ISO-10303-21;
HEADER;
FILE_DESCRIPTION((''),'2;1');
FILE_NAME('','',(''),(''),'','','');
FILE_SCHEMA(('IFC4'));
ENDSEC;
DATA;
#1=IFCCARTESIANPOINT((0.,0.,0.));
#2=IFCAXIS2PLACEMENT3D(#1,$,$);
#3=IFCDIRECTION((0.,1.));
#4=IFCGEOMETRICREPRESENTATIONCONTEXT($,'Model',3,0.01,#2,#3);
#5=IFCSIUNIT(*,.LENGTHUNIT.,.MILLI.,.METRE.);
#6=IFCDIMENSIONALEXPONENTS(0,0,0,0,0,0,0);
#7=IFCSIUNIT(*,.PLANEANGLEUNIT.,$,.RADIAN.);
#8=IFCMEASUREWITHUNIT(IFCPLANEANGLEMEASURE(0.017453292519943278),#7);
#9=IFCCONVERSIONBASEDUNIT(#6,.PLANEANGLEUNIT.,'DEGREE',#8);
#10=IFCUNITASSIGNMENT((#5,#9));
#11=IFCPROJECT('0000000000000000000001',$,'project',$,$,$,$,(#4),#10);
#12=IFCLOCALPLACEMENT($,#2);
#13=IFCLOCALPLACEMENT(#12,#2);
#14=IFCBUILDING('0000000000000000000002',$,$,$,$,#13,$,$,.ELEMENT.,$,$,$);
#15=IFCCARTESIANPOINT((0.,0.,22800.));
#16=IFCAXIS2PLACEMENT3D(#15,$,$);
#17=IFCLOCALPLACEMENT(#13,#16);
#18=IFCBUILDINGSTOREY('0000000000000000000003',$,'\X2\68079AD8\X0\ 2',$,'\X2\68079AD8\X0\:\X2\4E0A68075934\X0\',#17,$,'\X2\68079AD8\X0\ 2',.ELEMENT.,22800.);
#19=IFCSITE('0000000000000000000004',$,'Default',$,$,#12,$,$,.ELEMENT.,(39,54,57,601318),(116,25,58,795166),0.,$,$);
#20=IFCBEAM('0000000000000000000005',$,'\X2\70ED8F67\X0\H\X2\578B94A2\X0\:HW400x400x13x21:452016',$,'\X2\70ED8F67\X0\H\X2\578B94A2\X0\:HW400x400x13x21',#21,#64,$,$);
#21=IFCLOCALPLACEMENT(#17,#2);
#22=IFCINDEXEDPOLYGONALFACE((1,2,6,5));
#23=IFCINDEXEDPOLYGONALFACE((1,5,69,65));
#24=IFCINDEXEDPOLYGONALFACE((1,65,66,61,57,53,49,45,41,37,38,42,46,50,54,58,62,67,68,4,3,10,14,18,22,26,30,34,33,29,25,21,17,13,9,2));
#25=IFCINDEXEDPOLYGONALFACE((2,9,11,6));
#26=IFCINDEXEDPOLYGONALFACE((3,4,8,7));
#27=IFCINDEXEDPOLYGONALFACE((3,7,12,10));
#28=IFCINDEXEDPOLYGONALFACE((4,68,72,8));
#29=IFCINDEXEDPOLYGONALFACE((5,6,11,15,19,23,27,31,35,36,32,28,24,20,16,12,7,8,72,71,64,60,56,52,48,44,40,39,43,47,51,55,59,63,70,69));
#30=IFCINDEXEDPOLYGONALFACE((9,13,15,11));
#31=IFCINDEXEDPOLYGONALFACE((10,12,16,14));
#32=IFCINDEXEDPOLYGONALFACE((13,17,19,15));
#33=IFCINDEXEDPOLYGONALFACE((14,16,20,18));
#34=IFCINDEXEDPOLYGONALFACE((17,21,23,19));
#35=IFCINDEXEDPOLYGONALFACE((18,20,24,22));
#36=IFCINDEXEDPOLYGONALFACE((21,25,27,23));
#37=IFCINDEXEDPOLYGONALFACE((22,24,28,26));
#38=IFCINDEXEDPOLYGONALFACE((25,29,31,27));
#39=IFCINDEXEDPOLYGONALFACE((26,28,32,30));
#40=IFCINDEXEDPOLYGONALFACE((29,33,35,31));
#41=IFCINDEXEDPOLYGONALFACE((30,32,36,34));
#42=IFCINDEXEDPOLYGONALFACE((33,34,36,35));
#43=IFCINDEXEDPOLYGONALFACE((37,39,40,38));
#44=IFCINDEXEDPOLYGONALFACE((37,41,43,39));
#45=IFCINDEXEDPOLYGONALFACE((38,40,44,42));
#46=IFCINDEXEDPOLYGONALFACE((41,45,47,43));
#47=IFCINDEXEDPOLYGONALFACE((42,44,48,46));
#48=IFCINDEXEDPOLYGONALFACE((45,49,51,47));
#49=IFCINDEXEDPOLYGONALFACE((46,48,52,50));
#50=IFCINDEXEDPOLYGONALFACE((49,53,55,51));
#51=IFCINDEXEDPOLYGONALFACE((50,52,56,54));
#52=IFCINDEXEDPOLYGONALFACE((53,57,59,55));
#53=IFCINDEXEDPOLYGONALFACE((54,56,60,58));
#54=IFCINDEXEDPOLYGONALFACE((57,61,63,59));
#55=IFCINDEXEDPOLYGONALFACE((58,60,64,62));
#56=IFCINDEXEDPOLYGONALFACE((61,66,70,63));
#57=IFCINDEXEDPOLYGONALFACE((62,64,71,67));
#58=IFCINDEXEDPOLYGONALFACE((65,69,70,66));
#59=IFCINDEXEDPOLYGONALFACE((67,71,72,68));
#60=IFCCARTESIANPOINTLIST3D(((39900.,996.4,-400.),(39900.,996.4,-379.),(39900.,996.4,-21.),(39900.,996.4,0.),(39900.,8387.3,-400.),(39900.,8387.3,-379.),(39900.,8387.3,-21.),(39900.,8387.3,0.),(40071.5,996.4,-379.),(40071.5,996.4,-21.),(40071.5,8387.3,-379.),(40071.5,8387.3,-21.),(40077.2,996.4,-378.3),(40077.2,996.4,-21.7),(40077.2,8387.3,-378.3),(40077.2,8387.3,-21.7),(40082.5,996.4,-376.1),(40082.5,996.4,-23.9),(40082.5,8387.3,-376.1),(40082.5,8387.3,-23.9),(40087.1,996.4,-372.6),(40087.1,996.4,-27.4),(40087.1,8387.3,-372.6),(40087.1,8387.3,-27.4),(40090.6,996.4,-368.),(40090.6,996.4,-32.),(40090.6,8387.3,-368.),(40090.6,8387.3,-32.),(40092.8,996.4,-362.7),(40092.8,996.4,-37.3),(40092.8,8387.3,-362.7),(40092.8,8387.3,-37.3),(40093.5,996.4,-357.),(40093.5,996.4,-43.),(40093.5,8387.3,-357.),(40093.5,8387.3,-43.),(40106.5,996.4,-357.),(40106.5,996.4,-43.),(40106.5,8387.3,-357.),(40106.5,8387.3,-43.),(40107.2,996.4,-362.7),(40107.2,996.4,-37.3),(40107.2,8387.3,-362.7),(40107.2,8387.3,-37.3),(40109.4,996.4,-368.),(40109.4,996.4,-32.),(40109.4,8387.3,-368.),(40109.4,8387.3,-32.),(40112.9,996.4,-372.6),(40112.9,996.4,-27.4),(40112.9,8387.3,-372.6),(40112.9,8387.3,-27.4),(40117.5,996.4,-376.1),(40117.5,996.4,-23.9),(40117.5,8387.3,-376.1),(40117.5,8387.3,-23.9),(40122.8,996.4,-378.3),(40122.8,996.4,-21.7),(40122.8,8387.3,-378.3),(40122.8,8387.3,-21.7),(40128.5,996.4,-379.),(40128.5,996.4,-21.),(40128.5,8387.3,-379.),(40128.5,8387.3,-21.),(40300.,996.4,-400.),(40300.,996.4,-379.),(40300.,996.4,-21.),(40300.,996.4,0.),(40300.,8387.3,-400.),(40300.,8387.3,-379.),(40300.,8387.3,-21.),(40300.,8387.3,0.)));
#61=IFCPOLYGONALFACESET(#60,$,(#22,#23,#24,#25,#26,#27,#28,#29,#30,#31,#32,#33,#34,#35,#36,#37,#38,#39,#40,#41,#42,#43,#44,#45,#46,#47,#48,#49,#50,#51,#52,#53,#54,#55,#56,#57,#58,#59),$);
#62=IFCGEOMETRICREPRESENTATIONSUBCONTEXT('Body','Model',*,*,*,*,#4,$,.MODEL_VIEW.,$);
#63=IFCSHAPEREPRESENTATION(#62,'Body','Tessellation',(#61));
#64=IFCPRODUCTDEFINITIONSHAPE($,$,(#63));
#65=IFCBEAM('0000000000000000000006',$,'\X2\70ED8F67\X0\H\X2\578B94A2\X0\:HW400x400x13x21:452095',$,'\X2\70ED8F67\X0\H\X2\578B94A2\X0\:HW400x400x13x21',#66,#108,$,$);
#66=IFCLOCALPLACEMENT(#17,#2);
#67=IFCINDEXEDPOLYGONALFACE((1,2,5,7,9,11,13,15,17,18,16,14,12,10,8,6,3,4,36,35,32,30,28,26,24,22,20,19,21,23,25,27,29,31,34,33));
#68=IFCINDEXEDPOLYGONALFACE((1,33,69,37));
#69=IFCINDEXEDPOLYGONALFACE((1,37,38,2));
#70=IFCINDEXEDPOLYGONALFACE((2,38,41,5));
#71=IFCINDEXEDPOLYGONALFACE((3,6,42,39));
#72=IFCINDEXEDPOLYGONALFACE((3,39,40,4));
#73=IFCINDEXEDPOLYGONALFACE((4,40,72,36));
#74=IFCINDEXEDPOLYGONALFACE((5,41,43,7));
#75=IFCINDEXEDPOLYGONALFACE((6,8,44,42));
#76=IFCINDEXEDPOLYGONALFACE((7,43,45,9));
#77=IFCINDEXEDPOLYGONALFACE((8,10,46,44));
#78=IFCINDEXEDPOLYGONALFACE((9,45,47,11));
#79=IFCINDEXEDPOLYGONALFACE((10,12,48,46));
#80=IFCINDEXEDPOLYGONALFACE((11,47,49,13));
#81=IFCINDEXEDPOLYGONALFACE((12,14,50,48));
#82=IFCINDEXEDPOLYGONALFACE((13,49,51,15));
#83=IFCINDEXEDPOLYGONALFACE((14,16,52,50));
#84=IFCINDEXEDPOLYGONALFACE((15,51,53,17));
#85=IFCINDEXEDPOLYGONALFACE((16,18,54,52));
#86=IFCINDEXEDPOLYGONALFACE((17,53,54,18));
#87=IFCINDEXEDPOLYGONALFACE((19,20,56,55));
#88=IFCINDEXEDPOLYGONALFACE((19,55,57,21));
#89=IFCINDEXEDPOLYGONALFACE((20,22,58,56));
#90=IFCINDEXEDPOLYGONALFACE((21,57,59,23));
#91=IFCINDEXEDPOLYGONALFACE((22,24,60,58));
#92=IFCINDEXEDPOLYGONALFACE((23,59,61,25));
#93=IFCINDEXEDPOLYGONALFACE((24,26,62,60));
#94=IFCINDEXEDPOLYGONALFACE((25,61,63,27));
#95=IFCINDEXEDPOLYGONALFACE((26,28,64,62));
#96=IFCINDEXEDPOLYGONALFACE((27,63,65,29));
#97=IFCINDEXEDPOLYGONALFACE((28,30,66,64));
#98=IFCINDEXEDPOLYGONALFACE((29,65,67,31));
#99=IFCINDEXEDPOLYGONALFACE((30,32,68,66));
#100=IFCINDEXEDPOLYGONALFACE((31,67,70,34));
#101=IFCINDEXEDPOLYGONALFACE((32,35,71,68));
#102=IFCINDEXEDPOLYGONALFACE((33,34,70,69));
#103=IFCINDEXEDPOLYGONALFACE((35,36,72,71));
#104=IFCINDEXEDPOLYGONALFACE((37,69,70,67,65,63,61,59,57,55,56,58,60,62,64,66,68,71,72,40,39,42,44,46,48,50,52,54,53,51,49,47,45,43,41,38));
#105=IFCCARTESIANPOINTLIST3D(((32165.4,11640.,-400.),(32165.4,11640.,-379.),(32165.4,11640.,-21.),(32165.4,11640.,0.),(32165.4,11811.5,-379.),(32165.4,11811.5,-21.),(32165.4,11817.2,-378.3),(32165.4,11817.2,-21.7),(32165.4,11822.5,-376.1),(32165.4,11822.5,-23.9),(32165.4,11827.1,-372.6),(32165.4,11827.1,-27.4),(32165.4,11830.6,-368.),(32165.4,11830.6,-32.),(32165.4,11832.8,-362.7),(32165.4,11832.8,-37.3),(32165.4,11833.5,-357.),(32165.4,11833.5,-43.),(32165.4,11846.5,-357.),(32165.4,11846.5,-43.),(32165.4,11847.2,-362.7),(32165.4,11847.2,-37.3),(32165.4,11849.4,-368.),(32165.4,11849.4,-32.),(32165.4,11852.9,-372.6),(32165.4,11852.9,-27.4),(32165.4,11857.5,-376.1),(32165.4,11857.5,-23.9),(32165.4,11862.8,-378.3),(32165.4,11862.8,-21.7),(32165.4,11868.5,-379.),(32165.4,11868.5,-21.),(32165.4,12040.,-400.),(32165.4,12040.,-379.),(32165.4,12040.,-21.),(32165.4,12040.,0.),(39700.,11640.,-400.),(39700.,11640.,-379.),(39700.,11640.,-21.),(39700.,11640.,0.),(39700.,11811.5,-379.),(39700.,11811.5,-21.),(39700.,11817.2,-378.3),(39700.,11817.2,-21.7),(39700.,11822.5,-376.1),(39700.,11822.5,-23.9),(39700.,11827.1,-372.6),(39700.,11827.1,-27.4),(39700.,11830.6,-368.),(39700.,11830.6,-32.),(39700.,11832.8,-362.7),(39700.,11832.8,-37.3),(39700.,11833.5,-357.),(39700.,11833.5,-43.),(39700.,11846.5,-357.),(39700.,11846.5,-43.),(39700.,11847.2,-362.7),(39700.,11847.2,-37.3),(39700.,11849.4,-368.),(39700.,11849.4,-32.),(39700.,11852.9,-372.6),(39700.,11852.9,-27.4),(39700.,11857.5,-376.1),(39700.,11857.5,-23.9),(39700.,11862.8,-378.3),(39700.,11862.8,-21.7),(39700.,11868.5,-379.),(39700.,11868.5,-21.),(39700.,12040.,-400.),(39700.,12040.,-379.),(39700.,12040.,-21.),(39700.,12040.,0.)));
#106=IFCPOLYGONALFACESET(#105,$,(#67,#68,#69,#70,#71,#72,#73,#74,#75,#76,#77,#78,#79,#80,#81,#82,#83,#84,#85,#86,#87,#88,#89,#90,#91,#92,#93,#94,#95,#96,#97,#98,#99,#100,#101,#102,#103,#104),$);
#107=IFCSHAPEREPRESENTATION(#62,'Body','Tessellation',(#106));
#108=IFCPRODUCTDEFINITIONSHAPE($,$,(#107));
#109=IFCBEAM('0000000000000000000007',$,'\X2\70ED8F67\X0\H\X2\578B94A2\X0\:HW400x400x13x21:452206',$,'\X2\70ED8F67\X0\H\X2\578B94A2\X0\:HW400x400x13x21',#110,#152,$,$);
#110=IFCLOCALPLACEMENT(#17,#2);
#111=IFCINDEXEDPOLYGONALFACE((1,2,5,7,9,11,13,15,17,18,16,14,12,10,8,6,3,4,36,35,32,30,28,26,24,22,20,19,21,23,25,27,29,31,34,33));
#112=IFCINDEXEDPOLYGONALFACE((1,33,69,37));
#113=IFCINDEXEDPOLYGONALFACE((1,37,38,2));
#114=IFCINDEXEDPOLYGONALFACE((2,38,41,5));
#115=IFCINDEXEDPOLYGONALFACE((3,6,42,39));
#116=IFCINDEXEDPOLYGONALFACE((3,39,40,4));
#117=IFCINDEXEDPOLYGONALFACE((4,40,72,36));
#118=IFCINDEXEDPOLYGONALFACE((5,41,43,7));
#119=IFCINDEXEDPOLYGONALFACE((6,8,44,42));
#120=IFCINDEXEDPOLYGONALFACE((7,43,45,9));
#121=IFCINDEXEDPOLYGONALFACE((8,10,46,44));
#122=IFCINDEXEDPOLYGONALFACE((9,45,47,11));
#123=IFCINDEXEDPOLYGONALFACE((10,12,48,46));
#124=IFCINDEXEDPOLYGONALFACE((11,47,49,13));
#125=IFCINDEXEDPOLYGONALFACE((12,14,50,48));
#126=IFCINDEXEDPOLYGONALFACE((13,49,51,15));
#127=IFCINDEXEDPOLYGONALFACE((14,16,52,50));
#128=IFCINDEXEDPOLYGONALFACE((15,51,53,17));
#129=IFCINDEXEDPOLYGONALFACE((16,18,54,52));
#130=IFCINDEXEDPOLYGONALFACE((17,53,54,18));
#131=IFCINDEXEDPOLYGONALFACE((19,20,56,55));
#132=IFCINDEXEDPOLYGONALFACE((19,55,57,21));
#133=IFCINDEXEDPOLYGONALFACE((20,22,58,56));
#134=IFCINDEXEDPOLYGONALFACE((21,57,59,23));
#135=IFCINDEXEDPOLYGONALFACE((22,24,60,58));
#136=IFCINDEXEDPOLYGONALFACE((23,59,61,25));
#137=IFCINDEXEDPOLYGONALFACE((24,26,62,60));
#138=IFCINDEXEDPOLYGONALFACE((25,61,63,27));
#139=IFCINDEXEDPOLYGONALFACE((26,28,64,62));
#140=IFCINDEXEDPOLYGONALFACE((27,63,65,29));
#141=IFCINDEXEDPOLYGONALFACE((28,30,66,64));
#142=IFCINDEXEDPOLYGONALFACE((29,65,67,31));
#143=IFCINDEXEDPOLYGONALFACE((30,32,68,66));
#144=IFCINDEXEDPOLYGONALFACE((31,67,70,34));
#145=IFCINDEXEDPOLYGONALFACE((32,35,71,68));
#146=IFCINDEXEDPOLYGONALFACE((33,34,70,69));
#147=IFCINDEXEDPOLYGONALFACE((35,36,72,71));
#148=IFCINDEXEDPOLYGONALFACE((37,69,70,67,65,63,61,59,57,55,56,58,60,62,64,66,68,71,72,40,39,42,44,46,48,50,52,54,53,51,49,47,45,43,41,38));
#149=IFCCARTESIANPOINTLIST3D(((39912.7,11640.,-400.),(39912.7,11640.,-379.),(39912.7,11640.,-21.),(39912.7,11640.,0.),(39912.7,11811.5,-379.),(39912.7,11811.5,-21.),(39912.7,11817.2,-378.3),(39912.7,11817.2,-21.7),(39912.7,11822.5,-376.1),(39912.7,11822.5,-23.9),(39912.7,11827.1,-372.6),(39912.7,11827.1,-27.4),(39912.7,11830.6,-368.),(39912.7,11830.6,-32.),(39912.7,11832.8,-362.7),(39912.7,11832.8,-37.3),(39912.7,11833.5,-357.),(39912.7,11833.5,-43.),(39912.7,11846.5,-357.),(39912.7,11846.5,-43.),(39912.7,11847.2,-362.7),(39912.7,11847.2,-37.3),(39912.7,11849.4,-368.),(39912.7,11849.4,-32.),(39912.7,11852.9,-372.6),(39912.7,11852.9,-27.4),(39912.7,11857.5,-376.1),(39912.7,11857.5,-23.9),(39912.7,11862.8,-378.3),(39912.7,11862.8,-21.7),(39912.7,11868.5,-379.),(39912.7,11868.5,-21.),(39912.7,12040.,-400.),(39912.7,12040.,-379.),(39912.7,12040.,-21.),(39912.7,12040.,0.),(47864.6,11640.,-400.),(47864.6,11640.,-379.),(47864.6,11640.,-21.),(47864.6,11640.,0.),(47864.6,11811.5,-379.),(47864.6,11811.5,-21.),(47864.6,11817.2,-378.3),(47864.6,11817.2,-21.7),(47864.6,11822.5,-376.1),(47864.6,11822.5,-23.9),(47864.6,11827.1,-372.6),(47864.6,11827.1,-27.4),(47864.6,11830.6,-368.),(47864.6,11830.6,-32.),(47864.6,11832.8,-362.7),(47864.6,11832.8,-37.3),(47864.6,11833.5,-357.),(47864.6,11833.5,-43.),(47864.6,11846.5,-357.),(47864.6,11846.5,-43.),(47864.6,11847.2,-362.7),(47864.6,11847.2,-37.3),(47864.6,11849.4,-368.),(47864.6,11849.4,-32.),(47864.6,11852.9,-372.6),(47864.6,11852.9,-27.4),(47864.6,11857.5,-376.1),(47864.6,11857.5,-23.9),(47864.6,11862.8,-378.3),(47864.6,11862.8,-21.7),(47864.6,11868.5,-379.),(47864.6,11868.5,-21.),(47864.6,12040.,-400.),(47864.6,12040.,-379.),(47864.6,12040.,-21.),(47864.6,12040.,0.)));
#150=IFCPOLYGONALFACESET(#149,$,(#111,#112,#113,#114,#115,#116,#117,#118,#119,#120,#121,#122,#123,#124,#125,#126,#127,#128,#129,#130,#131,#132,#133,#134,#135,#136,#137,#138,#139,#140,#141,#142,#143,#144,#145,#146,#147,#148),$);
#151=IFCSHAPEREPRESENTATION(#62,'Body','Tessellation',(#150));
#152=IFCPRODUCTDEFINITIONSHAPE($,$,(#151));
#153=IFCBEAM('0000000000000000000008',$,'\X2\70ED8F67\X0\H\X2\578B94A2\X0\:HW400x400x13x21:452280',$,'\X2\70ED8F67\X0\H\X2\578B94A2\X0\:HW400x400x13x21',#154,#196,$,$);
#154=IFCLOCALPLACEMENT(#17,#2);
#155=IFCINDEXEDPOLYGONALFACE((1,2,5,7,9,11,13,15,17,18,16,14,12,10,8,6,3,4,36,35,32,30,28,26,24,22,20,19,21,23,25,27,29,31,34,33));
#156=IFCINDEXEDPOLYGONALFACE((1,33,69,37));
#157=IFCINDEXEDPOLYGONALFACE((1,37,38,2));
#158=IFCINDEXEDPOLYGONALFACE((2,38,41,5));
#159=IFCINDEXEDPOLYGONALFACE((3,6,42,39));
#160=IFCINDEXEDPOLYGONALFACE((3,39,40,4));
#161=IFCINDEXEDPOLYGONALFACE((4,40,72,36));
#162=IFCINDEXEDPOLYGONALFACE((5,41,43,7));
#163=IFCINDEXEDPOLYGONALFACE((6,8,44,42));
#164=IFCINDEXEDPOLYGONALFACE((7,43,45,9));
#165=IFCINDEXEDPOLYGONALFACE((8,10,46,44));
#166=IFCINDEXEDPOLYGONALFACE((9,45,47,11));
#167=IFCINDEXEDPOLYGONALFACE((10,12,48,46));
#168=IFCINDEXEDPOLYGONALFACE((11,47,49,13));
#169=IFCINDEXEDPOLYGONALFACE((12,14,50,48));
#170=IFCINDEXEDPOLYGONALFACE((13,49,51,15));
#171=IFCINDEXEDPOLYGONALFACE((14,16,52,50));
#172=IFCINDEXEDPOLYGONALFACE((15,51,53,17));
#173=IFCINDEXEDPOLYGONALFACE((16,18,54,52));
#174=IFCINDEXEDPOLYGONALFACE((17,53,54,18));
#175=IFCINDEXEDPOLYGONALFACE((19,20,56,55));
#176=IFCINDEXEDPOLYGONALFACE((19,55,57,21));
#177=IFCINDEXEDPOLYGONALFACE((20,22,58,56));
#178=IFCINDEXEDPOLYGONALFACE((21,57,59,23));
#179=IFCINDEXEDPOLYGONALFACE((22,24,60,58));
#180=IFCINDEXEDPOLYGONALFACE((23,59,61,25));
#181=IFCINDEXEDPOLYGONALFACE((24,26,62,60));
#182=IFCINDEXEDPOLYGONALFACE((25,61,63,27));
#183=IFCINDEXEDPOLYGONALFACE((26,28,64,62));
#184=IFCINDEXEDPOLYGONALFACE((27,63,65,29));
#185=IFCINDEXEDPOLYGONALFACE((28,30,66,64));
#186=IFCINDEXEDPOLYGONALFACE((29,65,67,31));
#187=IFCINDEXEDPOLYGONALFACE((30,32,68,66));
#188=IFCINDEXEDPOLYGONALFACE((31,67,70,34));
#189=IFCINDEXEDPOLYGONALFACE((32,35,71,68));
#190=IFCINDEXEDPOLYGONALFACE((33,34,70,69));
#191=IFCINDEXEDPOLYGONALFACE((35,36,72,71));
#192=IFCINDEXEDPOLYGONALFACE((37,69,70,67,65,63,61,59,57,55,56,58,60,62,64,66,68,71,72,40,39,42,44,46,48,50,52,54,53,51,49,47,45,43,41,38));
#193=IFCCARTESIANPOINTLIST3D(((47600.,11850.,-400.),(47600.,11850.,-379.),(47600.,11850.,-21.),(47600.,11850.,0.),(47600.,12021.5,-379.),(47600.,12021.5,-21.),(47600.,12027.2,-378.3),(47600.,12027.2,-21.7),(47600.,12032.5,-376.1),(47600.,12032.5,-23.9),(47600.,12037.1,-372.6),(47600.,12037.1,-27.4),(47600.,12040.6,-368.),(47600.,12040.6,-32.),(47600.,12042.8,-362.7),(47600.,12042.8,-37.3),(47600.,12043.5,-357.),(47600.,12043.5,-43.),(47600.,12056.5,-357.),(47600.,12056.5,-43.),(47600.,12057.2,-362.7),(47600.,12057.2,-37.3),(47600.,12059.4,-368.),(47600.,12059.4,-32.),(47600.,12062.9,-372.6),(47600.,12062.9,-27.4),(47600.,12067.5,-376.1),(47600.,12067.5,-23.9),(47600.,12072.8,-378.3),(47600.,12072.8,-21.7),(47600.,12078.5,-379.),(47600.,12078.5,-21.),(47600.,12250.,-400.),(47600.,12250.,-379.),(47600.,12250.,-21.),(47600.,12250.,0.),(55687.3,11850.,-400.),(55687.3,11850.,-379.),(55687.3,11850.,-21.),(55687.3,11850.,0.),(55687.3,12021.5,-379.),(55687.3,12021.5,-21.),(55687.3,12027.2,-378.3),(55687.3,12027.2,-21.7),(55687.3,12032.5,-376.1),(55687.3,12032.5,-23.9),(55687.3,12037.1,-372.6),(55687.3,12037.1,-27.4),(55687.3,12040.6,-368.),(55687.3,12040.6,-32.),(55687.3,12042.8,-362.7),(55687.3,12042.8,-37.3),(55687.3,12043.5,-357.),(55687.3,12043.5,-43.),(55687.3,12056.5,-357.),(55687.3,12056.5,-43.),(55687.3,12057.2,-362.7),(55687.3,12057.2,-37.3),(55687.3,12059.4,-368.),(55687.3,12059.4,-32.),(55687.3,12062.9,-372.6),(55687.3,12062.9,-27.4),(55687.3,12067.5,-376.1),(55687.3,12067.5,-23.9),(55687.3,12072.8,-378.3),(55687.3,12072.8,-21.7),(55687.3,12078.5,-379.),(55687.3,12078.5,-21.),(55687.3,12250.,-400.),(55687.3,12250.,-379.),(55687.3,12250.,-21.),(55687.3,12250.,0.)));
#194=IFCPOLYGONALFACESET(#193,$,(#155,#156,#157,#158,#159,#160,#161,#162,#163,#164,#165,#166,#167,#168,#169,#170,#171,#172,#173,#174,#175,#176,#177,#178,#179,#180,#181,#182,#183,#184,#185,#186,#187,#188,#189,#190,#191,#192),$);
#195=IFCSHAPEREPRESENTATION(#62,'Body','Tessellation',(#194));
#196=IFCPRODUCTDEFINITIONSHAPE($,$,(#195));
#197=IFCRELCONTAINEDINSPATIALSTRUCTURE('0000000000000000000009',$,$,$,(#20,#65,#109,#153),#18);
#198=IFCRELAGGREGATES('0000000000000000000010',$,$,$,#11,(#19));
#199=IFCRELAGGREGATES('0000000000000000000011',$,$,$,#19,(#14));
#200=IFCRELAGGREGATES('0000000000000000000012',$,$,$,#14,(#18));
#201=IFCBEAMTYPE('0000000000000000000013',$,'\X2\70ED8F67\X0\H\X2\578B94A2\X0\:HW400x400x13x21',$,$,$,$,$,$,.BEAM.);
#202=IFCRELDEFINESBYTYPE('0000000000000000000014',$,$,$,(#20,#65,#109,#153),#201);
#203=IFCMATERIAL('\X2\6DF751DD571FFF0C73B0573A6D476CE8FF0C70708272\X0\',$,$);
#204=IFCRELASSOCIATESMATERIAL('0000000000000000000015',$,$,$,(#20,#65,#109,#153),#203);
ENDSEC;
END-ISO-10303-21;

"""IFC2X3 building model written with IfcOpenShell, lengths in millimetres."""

from ifc_helpers import new_model, entity, si_unit, converted_unit, direction, frame, frame_2d, origin, place, context, subcontext, project, spatial, i_section, extrude, material, type_object, element, save


model = new_model("IFC2X3")

# Units and contexts
model_context = context("Model", 3, precision=0.01, world=origin(), true_north=direction((0.0, 1.0)))
body_context = subcontext(model_context, "Body", "Model", "MODEL_VIEW")
ifc_project = project(units=[si_unit("LENGTHUNIT", "METRE", prefix="MILLI"), converted_unit("PLANEANGLEUNIT", "DEGREE", entity("IfcPlaneAngleMeasure", 0.017453292519943278), si_unit("PLANEANGLEUNIT", "RADIAN"), dimensions=[0, 0, 0, 0, 0, 0, 0])], contexts=[model_context])

# Site, building, storey
site_placement = place(None, origin())
site = spatial("IfcSite", under=ifc_project, at=site_placement, Name="Default", CompositionType="ELEMENT", RefLatitude=(39, 54, 57, 601318), RefLongitude=(116, 25, 58, 795166), RefElevation=0.0)
building_placement = place(site_placement, origin())
building = spatial("IfcBuilding", under=site, at=building_placement, CompositionType="ELEMENT")
storey_placement = place(building_placement, frame((0.0, 0.0, 22800.0)))
storey = spatial("IfcBuildingStorey", under=building, at=storey_placement, Name="标高 2", ObjectType="标高:上标头", LongName="标高 2", CompositionType="ELEMENT", Elevation=22800.0)

# Beams
ifc_material = material(Name="混凝土，现场浇注，灰色")
beam_type = type_object("IfcBeamType", Name="热轧H型钢:HW400x400x13x21", PredefinedType="BEAM")
beam_1_placement = place(storey_placement, frame((40100.0, 8600.0, 0.0), z_axis=(0.0, 0.0, 1.0), x_axis=(0.0, -1.0, 0.0)))
element("IfcBeam", 1, at=beam_1_placement, inside=storey, type_object=beam_type, material=ifc_material, Name="热轧H型钢:HW400x400x13x21:452016", ObjectType="热轧H型钢:HW400x400x13x21", context=body_context, shape_type="SweptSolid", body=[
    extrude(i_section(OverallWidth=400.0, OverallDepth=400.0, WebThickness=13.0, FlangeThickness=21.0, FilletRadius=22.0, at=frame_2d((0.0, 0.0), x_axis=(0.0, 1.0))), frame((212.7, 0.0, -200.0), z_axis=(1.0, 0.0, 0.0), x_axis=(0.0, 0.0, -1.0)), (0.0, 0.0, 1.0), 7390.9),
])
beam_2_placement = place(storey_placement, frame((39700.0, 11840.0, 0.0), z_axis=(0.0, 0.0, 1.0), x_axis=(-1.0, 0.0, 0.0)))
element("IfcBeam", 2, at=beam_2_placement, inside=storey, type_object=beam_type, material=ifc_material, Name="热轧H型钢:HW400x400x13x21:452095", ObjectType="热轧H型钢:HW400x400x13x21", context=body_context, shape_type="SweptSolid", body=[
    extrude(i_section(OverallWidth=400.0, OverallDepth=400.0, WebThickness=13.0, FlangeThickness=21.0, FilletRadius=22.0, at=frame_2d((0.0, 0.0), x_axis=(0.0, 1.0))), frame((0.0, 0.0, -200.0), z_axis=(1.0, 0.0, 0.0), x_axis=(0.0, 0.0, -1.0)), (0.0, 0.0, 1.0), 7534.6),
])
beam_3_placement = place(storey_placement, frame((48125.0, 11840.0, 0.0), z_axis=(0.0, 0.0, 1.0), x_axis=(-1.0, 0.0, 0.0)))
element("IfcBeam", 3, at=beam_3_placement, inside=storey, type_object=beam_type, material=ifc_material, Name="热轧H型钢:HW400x400x13x21:452206", ObjectType="热轧H型钢:HW400x400x13x21", context=body_context, shape_type="SweptSolid", body=[
    extrude(i_section(OverallWidth=400.0, OverallDepth=400.0, WebThickness=13.0, FlangeThickness=21.0, FilletRadius=22.0, at=frame_2d((0.0, 0.0), x_axis=(0.0, 1.0))), frame((260.4, 0.0, -200.0), z_axis=(1.0, 0.0, 0.0), x_axis=(0.0, 0.0, -1.0)), (0.0, 0.0, 1.0), 7951.9),
])
beam_4_placement = place(storey_placement, frame((55900.0, 12050.0, 0.0), z_axis=(0.0, 0.0, 1.0), x_axis=(-1.0, 0.0, 0.0)))
element("IfcBeam", 4, at=beam_4_placement, inside=storey, type_object=beam_type, material=ifc_material, Name="热轧H型钢:HW400x400x13x21:452280", ObjectType="热轧H型钢:HW400x400x13x21", context=body_context, shape_type="SweptSolid", body=[
    extrude(i_section(OverallWidth=400.0, OverallDepth=400.0, WebThickness=13.0, FlangeThickness=21.0, FilletRadius=22.0, at=frame_2d((0.0, 0.0), x_axis=(0.0, 1.0))), frame((212.7, 0.0, -200.0), z_axis=(1.0, 0.0, 0.0), x_axis=(0.0, 0.0, -1.0)), (0.0, 0.0, 1.0), 8087.3),
])

save(model, "model.ifc")
